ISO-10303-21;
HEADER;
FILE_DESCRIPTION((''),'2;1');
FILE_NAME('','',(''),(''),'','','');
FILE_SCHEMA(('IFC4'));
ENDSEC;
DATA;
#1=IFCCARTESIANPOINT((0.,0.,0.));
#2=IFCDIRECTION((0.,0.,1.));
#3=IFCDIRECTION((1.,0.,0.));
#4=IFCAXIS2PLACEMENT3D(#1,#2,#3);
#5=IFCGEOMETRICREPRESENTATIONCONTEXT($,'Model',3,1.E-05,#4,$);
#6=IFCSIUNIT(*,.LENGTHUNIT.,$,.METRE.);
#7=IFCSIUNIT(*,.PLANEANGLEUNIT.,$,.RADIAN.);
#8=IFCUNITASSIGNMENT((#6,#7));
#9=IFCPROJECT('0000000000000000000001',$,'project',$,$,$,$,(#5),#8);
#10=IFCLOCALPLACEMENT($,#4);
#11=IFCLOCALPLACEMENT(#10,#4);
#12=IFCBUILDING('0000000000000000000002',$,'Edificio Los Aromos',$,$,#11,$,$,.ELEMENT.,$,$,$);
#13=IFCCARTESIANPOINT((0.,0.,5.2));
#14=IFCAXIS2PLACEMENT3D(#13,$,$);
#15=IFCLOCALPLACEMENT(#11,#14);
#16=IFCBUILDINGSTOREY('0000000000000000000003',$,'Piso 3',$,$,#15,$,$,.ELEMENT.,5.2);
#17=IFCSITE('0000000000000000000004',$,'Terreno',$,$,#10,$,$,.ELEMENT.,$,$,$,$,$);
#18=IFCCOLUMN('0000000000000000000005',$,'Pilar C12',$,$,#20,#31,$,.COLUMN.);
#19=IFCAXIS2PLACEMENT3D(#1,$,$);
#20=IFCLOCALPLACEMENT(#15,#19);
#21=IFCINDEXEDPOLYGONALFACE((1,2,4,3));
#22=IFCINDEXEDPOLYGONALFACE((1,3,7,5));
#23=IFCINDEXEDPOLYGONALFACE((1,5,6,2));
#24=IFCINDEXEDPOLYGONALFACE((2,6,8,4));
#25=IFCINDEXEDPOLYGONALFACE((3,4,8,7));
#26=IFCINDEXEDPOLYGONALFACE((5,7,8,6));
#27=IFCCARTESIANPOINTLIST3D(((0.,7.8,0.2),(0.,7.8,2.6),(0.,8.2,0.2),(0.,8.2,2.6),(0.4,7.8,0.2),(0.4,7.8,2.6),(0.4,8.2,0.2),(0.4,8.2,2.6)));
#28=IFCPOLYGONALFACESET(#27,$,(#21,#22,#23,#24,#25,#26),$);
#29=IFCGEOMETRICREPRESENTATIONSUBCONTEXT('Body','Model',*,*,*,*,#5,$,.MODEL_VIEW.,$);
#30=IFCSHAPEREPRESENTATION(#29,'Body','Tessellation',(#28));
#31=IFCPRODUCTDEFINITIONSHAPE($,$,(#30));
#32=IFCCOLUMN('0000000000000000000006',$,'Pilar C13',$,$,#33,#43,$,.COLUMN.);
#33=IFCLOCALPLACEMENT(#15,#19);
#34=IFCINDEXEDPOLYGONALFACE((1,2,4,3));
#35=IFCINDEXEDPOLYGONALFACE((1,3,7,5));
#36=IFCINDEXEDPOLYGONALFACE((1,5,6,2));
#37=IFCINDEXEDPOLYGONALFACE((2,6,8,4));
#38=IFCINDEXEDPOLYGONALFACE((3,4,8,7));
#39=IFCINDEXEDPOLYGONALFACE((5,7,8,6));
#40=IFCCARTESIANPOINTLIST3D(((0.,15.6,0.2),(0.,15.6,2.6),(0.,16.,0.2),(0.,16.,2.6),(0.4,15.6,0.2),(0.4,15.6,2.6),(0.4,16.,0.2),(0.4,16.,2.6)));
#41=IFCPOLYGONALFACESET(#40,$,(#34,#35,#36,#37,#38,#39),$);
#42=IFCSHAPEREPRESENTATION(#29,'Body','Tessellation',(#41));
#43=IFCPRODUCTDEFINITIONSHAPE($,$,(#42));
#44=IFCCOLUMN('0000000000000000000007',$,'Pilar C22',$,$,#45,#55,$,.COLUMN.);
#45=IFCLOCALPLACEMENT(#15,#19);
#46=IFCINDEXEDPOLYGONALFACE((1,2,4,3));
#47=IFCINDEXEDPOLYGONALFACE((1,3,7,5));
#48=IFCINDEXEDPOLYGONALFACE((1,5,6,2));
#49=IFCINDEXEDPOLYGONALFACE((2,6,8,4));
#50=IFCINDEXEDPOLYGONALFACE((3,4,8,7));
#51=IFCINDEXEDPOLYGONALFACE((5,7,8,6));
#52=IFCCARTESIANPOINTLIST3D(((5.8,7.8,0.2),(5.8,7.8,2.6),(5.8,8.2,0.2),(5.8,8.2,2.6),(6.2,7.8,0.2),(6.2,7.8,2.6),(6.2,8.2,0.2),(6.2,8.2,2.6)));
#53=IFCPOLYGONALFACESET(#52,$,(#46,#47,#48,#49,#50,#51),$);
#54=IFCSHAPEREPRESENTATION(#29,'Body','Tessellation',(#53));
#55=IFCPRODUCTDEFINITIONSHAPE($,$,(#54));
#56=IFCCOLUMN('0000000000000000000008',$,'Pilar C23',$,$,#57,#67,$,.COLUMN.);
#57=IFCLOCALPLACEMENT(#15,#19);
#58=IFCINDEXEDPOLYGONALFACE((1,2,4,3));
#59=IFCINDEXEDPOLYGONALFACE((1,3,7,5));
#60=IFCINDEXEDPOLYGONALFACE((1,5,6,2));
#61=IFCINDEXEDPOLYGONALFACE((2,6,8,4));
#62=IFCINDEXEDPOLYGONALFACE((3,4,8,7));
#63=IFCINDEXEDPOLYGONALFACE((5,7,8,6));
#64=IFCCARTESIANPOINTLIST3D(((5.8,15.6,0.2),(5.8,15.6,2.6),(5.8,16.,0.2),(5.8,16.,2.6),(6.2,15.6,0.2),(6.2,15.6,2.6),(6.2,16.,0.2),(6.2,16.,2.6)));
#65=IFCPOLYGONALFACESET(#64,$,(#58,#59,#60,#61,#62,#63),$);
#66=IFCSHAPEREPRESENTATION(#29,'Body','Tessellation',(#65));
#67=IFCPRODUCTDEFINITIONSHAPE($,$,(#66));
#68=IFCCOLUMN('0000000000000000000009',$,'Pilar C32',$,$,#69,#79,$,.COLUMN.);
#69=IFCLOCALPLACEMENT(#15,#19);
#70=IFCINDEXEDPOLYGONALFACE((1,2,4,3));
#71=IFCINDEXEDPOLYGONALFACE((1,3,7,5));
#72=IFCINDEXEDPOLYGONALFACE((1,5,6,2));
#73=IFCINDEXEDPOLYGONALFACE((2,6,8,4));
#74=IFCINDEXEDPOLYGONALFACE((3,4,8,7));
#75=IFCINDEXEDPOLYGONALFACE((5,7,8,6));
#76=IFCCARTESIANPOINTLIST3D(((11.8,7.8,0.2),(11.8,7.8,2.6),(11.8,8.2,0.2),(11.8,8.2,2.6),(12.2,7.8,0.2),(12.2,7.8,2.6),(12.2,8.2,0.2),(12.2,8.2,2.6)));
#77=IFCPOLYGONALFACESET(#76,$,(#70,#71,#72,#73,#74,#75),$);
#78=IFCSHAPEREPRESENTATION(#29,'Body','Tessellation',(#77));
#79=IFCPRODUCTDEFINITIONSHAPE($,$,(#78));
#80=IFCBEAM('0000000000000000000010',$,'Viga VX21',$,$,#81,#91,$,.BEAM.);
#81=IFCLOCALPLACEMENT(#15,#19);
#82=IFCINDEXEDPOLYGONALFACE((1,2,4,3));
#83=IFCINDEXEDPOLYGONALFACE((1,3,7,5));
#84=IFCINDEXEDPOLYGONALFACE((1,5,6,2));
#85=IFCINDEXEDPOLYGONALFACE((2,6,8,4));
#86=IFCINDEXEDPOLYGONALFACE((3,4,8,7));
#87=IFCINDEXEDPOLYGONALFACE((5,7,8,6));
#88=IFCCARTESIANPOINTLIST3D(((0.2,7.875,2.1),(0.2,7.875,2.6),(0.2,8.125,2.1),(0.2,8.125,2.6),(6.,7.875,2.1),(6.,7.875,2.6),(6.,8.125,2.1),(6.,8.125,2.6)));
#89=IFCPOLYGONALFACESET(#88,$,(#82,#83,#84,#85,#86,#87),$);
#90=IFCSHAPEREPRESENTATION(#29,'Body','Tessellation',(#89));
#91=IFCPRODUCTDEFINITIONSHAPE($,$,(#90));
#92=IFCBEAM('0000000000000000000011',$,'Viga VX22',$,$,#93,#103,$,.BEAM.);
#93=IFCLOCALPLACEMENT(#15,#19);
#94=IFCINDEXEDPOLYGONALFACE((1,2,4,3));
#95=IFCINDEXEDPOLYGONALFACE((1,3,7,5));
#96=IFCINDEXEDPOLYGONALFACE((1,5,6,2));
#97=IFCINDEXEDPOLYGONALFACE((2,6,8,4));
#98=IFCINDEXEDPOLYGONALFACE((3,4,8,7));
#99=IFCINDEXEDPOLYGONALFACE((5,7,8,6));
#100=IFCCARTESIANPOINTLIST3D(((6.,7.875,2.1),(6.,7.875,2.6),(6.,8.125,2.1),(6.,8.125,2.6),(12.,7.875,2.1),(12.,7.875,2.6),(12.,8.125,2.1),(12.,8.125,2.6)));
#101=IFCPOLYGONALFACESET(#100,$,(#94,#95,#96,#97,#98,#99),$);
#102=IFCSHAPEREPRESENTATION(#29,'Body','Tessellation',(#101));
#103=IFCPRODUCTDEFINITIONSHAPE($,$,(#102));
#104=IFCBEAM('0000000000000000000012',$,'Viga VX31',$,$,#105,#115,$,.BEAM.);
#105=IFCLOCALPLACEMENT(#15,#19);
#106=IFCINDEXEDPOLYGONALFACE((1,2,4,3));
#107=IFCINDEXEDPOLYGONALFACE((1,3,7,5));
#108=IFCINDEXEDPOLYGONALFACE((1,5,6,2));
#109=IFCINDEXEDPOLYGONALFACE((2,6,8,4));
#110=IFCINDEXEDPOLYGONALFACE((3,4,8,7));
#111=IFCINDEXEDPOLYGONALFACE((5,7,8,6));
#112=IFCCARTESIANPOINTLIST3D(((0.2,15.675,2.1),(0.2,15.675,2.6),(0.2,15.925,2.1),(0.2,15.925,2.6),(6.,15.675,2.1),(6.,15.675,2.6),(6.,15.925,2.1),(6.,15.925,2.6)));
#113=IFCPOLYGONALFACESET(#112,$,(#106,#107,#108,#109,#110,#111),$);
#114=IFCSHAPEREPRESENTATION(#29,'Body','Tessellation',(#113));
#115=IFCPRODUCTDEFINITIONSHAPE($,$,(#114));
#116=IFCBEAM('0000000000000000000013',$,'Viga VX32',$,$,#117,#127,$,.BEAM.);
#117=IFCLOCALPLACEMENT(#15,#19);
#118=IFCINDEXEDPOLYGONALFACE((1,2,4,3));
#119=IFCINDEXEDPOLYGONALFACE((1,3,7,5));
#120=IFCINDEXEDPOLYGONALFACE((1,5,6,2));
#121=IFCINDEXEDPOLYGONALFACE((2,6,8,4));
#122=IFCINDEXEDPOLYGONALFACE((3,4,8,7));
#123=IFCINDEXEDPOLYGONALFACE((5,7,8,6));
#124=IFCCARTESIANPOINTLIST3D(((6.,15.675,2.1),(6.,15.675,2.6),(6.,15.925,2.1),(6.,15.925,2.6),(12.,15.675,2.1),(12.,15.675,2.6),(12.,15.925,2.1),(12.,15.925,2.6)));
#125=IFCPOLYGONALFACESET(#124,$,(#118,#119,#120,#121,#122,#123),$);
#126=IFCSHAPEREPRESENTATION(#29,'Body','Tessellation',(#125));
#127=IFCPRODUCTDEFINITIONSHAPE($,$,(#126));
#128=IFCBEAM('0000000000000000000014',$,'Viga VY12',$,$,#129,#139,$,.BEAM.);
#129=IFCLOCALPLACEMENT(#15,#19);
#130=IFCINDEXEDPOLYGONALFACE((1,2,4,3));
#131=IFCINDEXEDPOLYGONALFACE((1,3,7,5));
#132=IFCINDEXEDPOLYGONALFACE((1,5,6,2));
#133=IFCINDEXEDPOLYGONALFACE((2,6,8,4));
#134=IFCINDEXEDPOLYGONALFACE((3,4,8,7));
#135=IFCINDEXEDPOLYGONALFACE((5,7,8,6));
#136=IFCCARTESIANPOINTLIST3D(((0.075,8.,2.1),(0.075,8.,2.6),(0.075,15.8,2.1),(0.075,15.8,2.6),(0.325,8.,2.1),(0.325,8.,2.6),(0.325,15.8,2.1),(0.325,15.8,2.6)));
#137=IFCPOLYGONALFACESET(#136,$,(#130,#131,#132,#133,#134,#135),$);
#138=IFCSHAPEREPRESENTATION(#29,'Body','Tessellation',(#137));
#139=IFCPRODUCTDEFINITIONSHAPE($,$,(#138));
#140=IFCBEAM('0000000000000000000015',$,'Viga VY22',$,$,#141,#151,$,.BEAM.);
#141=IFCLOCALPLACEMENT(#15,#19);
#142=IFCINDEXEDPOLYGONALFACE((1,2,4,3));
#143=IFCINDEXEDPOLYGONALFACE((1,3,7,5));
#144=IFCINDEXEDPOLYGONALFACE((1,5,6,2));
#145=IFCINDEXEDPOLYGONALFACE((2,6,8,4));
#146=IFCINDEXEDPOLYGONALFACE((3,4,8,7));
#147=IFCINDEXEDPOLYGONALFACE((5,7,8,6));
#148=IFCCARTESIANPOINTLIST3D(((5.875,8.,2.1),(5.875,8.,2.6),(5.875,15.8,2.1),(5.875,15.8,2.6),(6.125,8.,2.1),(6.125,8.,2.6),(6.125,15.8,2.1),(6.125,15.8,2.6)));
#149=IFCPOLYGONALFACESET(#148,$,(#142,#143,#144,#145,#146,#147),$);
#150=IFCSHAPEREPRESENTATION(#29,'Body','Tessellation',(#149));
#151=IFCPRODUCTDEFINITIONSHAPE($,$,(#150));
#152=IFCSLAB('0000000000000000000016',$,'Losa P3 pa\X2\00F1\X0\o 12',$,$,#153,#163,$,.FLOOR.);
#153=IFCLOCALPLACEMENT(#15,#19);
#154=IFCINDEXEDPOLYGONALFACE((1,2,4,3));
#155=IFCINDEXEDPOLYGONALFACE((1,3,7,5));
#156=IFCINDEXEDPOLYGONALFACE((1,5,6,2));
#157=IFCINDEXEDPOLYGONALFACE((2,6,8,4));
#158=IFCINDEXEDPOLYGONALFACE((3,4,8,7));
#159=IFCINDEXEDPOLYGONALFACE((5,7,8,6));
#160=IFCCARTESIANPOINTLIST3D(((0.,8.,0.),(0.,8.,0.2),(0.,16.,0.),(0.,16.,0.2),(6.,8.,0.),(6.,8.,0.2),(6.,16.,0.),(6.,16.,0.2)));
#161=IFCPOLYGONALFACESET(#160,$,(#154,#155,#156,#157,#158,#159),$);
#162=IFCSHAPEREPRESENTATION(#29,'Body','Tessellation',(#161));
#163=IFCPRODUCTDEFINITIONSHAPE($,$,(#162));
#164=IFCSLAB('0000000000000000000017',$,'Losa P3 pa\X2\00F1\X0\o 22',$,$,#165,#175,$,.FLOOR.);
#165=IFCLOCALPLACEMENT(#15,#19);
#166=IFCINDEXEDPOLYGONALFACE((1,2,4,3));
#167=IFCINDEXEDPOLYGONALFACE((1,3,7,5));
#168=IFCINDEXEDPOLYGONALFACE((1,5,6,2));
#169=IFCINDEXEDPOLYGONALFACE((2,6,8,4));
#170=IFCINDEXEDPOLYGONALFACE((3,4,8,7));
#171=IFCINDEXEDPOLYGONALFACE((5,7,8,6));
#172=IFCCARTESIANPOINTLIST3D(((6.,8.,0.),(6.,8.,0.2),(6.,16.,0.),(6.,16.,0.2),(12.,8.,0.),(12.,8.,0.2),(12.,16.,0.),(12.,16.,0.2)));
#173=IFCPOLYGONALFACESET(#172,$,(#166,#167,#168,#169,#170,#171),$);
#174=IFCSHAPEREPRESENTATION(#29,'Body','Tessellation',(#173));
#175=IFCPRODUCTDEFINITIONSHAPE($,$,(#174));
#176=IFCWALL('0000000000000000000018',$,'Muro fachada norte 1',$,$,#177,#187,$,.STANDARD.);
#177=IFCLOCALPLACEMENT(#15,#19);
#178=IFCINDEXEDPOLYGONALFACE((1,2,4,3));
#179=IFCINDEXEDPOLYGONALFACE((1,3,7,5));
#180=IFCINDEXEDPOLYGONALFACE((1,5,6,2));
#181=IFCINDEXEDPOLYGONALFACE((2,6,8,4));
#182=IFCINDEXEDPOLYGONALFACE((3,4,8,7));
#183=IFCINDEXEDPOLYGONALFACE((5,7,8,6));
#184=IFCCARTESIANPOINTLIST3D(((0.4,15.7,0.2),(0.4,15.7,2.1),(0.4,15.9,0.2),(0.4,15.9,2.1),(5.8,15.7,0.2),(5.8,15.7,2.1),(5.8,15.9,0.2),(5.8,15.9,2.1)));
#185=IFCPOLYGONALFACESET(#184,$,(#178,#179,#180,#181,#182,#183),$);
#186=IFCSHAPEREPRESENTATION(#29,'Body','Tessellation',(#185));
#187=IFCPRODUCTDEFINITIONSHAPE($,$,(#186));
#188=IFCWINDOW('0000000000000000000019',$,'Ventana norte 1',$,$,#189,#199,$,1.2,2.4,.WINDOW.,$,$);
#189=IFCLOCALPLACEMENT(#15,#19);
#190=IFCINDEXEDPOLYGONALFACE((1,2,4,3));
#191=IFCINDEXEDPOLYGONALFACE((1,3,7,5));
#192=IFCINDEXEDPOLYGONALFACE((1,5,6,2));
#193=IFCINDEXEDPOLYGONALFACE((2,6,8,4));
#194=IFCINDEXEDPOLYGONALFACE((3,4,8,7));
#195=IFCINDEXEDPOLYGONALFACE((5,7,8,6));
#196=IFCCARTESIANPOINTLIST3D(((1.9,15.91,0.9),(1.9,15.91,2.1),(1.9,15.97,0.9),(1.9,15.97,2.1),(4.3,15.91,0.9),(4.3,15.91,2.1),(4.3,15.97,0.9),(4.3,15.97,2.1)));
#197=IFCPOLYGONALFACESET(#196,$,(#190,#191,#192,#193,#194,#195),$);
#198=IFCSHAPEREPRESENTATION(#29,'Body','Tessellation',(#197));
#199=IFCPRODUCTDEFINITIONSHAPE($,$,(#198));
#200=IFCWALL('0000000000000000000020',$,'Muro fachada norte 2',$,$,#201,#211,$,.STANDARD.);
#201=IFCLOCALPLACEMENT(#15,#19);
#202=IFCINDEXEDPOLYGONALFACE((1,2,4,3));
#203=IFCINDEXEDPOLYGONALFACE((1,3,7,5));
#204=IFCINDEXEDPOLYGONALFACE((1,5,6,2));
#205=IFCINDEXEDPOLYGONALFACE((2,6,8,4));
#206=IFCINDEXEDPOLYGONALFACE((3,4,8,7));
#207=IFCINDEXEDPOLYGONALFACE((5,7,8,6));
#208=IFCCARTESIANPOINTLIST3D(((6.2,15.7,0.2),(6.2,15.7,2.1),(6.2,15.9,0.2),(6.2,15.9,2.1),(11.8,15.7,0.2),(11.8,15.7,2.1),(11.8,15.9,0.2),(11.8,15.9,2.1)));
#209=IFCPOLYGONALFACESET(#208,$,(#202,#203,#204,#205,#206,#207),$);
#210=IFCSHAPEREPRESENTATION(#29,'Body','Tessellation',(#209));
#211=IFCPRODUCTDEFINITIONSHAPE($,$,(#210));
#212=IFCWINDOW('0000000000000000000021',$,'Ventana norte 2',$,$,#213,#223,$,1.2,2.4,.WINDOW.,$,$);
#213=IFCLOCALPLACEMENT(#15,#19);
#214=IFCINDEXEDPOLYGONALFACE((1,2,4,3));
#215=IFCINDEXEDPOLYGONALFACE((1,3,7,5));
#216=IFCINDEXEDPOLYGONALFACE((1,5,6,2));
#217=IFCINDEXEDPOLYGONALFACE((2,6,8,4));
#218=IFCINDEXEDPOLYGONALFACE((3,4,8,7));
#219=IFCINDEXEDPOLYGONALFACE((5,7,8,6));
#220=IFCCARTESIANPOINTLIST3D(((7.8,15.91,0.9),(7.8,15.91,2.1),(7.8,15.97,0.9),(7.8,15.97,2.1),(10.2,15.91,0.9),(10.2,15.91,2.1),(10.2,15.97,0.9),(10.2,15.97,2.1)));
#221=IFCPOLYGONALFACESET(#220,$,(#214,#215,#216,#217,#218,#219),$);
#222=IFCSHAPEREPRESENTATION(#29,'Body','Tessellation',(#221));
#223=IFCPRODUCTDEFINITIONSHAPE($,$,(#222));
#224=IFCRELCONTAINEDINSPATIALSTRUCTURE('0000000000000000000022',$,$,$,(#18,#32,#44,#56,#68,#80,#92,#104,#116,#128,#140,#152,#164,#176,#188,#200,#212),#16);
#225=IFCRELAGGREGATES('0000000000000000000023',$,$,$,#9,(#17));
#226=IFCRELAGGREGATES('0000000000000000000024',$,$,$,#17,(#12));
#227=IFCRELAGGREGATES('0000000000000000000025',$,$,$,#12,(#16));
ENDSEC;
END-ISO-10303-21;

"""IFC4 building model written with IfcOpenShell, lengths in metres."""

from ifc_helpers import new_model, si_unit, frame, frame_2d, origin_with_axes, place, context, subcontext, project, spatial, rectangle, extrude, element, save


model = new_model("IFC4")

# Units and contexts
model_context = context("Model", 3, precision=1e-05, world=origin_with_axes())
body_context = subcontext(model_context, "Body", "Model", "MODEL_VIEW")
ifc_project = project(units=[si_unit("LENGTHUNIT", "METRE"), si_unit("PLANEANGLEUNIT", "RADIAN")], contexts=[model_context])

# Site, building, storey
site_placement = place(None, origin_with_axes())
site = spatial("IfcSite", under=ifc_project, at=site_placement, Name="Terreno", CompositionType="ELEMENT")
building_placement = place(site_placement, origin_with_axes())
building = spatial("IfcBuilding", under=site, at=building_placement, Name="Edificio Los Aromos", CompositionType="ELEMENT")
storey_placement = place(building_placement, frame((0.0, 0.0, 5.2)))
storey = spatial("IfcBuildingStorey", under=building, at=storey_placement, Name="Piso 3", CompositionType="ELEMENT", Elevation=5.2)

# Columns
for number, where, name in (
    (1, (0.0, 7.8, 0.2), "Pilar C12"),
    (2, (0.0, 15.6, 0.2), "Pilar C13"),
    (3, (5.8, 7.8, 0.2), "Pilar C22"),
    (4, (5.8, 15.6, 0.2), "Pilar C23"),
    (5, (11.8, 7.8, 0.2), "Pilar C32"),
):
    element("IfcColumn", number, at=place(storey_placement, frame(where)), inside=storey, Name=name, PredefinedType="COLUMN", context=body_context, shape_type="SweptSolid", body=[
        extrude(rectangle(XDim=0.4, YDim=0.4, at=frame_2d((0.2, 0.2))), origin_with_axes(), (0.0, 0.0, 1.0), 2.4),
    ])

# Beams
beam_1_placement = place(storey_placement, frame((0.2, 7.875, 2.1)))
element("IfcBeam", 6, at=beam_1_placement, inside=storey, Name="Viga VX21", PredefinedType="BEAM", context=body_context, shape_type="SweptSolid", body=[
    extrude(rectangle(XDim=5.8, YDim=0.25, at=frame_2d((2.9, 0.125))), origin_with_axes(), (0.0, 0.0, 1.0), 0.5),
])
beam_2_placement = place(storey_placement, frame((6.0, 7.875, 2.1)))
element("IfcBeam", 7, at=beam_2_placement, inside=storey, Name="Viga VX22", PredefinedType="BEAM", context=body_context, shape_type="SweptSolid", body=[
    extrude(rectangle(XDim=6.0, YDim=0.25, at=frame_2d((3.0, 0.125))), origin_with_axes(), (0.0, 0.0, 1.0), 0.5),
])
beam_3_placement = place(storey_placement, frame((0.2, 15.675, 2.1)))
element("IfcBeam", 8, at=beam_3_placement, inside=storey, Name="Viga VX31", PredefinedType="BEAM", context=body_context, shape_type="SweptSolid", body=[
    extrude(rectangle(XDim=5.8, YDim=0.25, at=frame_2d((2.9, 0.125))), origin_with_axes(), (0.0, 0.0, 1.0), 0.5),
])
beam_4_placement = place(storey_placement, frame((6.0, 15.675, 2.1)))
element("IfcBeam", 9, at=beam_4_placement, inside=storey, Name="Viga VX32", PredefinedType="BEAM", context=body_context, shape_type="SweptSolid", body=[
    extrude(rectangle(XDim=6.0, YDim=0.25, at=frame_2d((3.0, 0.125))), origin_with_axes(), (0.0, 0.0, 1.0), 0.5),
])
for number, where, name in (
    (10, (0.075, 8.0, 2.1), "Viga VY12"),
    (11, (5.875, 8.0, 2.1), "Viga VY22"),
):
    element("IfcBeam", number, at=place(storey_placement, frame(where)), inside=storey, Name=name, PredefinedType="BEAM", context=body_context, shape_type="SweptSolid", body=[
        extrude(rectangle(XDim=0.25, YDim=7.8, at=frame_2d((0.125, 3.9))), origin_with_axes(), (0.0, 0.0, 1.0), 0.5),
    ])

# Slabs
for number, where, name in (
    (12, (0.0, 8.0, 0.0), "Losa P3 paño 12"),
    (13, (6.0, 8.0, 0.0), "Losa P3 paño 22"),
):
    element("IfcSlab", number, at=place(storey_placement, frame(where)), inside=storey, Name=name, PredefinedType="FLOOR", context=body_context, shape_type="SweptSolid", body=[
        extrude(rectangle(XDim=6.0, YDim=8.0, at=frame_2d((3.0, 4.0))), origin_with_axes(), (0.0, 0.0, 1.0), 0.2),
    ])

# Wall
wall_1_placement = place(storey_placement, frame((0.4, 15.7, 0.2)))
element("IfcWall", 14, at=wall_1_placement, inside=storey, Name="Muro fachada norte 1", PredefinedType="STANDARD", context=body_context, shape_type="SweptSolid", body=[
    extrude(rectangle(XDim=5.4, YDim=0.2, at=frame_2d((2.7, 0.1))), origin_with_axes(), (0.0, 0.0, 1.0), 1.9),
])

# Window
window_1_placement = place(storey_placement, frame((1.9, 15.91, 0.9)))
element("IfcWindow", 15, at=window_1_placement, inside=storey, Name="Ventana norte 1", OverallHeight=1.2, OverallWidth=2.4, PredefinedType="WINDOW", context=body_context, shape_type="SweptSolid", body=[
    extrude(rectangle(XDim=2.4, YDim=0.06, at=frame_2d((1.2, 0.03))), origin_with_axes(), (0.0, 0.0, 1.0), 1.2),
])

# Wall
wall_2_placement = place(storey_placement, frame((6.2, 15.7, 0.2)))
element("IfcWall", 16, at=wall_2_placement, inside=storey, Name="Muro fachada norte 2", PredefinedType="STANDARD", context=body_context, shape_type="SweptSolid", body=[
    extrude(rectangle(XDim=5.6, YDim=0.2, at=frame_2d((2.8, 0.1))), origin_with_axes(), (0.0, 0.0, 1.0), 1.9),
])

# Window
window_2_placement = place(storey_placement, frame((7.8, 15.91, 0.9)))
element("IfcWindow", 17, at=window_2_placement, inside=storey, Name="Ventana norte 2", OverallHeight=1.2, OverallWidth=2.4, PredefinedType="WINDOW", context=body_context, shape_type="SweptSolid", body=[
    extrude(rectangle(XDim=2.4, YDim=0.06, at=frame_2d((1.2, 0.03))), origin_with_axes(), (0.0, 0.0, 1.0), 1.2),
])

save(model, "model.ifc")
